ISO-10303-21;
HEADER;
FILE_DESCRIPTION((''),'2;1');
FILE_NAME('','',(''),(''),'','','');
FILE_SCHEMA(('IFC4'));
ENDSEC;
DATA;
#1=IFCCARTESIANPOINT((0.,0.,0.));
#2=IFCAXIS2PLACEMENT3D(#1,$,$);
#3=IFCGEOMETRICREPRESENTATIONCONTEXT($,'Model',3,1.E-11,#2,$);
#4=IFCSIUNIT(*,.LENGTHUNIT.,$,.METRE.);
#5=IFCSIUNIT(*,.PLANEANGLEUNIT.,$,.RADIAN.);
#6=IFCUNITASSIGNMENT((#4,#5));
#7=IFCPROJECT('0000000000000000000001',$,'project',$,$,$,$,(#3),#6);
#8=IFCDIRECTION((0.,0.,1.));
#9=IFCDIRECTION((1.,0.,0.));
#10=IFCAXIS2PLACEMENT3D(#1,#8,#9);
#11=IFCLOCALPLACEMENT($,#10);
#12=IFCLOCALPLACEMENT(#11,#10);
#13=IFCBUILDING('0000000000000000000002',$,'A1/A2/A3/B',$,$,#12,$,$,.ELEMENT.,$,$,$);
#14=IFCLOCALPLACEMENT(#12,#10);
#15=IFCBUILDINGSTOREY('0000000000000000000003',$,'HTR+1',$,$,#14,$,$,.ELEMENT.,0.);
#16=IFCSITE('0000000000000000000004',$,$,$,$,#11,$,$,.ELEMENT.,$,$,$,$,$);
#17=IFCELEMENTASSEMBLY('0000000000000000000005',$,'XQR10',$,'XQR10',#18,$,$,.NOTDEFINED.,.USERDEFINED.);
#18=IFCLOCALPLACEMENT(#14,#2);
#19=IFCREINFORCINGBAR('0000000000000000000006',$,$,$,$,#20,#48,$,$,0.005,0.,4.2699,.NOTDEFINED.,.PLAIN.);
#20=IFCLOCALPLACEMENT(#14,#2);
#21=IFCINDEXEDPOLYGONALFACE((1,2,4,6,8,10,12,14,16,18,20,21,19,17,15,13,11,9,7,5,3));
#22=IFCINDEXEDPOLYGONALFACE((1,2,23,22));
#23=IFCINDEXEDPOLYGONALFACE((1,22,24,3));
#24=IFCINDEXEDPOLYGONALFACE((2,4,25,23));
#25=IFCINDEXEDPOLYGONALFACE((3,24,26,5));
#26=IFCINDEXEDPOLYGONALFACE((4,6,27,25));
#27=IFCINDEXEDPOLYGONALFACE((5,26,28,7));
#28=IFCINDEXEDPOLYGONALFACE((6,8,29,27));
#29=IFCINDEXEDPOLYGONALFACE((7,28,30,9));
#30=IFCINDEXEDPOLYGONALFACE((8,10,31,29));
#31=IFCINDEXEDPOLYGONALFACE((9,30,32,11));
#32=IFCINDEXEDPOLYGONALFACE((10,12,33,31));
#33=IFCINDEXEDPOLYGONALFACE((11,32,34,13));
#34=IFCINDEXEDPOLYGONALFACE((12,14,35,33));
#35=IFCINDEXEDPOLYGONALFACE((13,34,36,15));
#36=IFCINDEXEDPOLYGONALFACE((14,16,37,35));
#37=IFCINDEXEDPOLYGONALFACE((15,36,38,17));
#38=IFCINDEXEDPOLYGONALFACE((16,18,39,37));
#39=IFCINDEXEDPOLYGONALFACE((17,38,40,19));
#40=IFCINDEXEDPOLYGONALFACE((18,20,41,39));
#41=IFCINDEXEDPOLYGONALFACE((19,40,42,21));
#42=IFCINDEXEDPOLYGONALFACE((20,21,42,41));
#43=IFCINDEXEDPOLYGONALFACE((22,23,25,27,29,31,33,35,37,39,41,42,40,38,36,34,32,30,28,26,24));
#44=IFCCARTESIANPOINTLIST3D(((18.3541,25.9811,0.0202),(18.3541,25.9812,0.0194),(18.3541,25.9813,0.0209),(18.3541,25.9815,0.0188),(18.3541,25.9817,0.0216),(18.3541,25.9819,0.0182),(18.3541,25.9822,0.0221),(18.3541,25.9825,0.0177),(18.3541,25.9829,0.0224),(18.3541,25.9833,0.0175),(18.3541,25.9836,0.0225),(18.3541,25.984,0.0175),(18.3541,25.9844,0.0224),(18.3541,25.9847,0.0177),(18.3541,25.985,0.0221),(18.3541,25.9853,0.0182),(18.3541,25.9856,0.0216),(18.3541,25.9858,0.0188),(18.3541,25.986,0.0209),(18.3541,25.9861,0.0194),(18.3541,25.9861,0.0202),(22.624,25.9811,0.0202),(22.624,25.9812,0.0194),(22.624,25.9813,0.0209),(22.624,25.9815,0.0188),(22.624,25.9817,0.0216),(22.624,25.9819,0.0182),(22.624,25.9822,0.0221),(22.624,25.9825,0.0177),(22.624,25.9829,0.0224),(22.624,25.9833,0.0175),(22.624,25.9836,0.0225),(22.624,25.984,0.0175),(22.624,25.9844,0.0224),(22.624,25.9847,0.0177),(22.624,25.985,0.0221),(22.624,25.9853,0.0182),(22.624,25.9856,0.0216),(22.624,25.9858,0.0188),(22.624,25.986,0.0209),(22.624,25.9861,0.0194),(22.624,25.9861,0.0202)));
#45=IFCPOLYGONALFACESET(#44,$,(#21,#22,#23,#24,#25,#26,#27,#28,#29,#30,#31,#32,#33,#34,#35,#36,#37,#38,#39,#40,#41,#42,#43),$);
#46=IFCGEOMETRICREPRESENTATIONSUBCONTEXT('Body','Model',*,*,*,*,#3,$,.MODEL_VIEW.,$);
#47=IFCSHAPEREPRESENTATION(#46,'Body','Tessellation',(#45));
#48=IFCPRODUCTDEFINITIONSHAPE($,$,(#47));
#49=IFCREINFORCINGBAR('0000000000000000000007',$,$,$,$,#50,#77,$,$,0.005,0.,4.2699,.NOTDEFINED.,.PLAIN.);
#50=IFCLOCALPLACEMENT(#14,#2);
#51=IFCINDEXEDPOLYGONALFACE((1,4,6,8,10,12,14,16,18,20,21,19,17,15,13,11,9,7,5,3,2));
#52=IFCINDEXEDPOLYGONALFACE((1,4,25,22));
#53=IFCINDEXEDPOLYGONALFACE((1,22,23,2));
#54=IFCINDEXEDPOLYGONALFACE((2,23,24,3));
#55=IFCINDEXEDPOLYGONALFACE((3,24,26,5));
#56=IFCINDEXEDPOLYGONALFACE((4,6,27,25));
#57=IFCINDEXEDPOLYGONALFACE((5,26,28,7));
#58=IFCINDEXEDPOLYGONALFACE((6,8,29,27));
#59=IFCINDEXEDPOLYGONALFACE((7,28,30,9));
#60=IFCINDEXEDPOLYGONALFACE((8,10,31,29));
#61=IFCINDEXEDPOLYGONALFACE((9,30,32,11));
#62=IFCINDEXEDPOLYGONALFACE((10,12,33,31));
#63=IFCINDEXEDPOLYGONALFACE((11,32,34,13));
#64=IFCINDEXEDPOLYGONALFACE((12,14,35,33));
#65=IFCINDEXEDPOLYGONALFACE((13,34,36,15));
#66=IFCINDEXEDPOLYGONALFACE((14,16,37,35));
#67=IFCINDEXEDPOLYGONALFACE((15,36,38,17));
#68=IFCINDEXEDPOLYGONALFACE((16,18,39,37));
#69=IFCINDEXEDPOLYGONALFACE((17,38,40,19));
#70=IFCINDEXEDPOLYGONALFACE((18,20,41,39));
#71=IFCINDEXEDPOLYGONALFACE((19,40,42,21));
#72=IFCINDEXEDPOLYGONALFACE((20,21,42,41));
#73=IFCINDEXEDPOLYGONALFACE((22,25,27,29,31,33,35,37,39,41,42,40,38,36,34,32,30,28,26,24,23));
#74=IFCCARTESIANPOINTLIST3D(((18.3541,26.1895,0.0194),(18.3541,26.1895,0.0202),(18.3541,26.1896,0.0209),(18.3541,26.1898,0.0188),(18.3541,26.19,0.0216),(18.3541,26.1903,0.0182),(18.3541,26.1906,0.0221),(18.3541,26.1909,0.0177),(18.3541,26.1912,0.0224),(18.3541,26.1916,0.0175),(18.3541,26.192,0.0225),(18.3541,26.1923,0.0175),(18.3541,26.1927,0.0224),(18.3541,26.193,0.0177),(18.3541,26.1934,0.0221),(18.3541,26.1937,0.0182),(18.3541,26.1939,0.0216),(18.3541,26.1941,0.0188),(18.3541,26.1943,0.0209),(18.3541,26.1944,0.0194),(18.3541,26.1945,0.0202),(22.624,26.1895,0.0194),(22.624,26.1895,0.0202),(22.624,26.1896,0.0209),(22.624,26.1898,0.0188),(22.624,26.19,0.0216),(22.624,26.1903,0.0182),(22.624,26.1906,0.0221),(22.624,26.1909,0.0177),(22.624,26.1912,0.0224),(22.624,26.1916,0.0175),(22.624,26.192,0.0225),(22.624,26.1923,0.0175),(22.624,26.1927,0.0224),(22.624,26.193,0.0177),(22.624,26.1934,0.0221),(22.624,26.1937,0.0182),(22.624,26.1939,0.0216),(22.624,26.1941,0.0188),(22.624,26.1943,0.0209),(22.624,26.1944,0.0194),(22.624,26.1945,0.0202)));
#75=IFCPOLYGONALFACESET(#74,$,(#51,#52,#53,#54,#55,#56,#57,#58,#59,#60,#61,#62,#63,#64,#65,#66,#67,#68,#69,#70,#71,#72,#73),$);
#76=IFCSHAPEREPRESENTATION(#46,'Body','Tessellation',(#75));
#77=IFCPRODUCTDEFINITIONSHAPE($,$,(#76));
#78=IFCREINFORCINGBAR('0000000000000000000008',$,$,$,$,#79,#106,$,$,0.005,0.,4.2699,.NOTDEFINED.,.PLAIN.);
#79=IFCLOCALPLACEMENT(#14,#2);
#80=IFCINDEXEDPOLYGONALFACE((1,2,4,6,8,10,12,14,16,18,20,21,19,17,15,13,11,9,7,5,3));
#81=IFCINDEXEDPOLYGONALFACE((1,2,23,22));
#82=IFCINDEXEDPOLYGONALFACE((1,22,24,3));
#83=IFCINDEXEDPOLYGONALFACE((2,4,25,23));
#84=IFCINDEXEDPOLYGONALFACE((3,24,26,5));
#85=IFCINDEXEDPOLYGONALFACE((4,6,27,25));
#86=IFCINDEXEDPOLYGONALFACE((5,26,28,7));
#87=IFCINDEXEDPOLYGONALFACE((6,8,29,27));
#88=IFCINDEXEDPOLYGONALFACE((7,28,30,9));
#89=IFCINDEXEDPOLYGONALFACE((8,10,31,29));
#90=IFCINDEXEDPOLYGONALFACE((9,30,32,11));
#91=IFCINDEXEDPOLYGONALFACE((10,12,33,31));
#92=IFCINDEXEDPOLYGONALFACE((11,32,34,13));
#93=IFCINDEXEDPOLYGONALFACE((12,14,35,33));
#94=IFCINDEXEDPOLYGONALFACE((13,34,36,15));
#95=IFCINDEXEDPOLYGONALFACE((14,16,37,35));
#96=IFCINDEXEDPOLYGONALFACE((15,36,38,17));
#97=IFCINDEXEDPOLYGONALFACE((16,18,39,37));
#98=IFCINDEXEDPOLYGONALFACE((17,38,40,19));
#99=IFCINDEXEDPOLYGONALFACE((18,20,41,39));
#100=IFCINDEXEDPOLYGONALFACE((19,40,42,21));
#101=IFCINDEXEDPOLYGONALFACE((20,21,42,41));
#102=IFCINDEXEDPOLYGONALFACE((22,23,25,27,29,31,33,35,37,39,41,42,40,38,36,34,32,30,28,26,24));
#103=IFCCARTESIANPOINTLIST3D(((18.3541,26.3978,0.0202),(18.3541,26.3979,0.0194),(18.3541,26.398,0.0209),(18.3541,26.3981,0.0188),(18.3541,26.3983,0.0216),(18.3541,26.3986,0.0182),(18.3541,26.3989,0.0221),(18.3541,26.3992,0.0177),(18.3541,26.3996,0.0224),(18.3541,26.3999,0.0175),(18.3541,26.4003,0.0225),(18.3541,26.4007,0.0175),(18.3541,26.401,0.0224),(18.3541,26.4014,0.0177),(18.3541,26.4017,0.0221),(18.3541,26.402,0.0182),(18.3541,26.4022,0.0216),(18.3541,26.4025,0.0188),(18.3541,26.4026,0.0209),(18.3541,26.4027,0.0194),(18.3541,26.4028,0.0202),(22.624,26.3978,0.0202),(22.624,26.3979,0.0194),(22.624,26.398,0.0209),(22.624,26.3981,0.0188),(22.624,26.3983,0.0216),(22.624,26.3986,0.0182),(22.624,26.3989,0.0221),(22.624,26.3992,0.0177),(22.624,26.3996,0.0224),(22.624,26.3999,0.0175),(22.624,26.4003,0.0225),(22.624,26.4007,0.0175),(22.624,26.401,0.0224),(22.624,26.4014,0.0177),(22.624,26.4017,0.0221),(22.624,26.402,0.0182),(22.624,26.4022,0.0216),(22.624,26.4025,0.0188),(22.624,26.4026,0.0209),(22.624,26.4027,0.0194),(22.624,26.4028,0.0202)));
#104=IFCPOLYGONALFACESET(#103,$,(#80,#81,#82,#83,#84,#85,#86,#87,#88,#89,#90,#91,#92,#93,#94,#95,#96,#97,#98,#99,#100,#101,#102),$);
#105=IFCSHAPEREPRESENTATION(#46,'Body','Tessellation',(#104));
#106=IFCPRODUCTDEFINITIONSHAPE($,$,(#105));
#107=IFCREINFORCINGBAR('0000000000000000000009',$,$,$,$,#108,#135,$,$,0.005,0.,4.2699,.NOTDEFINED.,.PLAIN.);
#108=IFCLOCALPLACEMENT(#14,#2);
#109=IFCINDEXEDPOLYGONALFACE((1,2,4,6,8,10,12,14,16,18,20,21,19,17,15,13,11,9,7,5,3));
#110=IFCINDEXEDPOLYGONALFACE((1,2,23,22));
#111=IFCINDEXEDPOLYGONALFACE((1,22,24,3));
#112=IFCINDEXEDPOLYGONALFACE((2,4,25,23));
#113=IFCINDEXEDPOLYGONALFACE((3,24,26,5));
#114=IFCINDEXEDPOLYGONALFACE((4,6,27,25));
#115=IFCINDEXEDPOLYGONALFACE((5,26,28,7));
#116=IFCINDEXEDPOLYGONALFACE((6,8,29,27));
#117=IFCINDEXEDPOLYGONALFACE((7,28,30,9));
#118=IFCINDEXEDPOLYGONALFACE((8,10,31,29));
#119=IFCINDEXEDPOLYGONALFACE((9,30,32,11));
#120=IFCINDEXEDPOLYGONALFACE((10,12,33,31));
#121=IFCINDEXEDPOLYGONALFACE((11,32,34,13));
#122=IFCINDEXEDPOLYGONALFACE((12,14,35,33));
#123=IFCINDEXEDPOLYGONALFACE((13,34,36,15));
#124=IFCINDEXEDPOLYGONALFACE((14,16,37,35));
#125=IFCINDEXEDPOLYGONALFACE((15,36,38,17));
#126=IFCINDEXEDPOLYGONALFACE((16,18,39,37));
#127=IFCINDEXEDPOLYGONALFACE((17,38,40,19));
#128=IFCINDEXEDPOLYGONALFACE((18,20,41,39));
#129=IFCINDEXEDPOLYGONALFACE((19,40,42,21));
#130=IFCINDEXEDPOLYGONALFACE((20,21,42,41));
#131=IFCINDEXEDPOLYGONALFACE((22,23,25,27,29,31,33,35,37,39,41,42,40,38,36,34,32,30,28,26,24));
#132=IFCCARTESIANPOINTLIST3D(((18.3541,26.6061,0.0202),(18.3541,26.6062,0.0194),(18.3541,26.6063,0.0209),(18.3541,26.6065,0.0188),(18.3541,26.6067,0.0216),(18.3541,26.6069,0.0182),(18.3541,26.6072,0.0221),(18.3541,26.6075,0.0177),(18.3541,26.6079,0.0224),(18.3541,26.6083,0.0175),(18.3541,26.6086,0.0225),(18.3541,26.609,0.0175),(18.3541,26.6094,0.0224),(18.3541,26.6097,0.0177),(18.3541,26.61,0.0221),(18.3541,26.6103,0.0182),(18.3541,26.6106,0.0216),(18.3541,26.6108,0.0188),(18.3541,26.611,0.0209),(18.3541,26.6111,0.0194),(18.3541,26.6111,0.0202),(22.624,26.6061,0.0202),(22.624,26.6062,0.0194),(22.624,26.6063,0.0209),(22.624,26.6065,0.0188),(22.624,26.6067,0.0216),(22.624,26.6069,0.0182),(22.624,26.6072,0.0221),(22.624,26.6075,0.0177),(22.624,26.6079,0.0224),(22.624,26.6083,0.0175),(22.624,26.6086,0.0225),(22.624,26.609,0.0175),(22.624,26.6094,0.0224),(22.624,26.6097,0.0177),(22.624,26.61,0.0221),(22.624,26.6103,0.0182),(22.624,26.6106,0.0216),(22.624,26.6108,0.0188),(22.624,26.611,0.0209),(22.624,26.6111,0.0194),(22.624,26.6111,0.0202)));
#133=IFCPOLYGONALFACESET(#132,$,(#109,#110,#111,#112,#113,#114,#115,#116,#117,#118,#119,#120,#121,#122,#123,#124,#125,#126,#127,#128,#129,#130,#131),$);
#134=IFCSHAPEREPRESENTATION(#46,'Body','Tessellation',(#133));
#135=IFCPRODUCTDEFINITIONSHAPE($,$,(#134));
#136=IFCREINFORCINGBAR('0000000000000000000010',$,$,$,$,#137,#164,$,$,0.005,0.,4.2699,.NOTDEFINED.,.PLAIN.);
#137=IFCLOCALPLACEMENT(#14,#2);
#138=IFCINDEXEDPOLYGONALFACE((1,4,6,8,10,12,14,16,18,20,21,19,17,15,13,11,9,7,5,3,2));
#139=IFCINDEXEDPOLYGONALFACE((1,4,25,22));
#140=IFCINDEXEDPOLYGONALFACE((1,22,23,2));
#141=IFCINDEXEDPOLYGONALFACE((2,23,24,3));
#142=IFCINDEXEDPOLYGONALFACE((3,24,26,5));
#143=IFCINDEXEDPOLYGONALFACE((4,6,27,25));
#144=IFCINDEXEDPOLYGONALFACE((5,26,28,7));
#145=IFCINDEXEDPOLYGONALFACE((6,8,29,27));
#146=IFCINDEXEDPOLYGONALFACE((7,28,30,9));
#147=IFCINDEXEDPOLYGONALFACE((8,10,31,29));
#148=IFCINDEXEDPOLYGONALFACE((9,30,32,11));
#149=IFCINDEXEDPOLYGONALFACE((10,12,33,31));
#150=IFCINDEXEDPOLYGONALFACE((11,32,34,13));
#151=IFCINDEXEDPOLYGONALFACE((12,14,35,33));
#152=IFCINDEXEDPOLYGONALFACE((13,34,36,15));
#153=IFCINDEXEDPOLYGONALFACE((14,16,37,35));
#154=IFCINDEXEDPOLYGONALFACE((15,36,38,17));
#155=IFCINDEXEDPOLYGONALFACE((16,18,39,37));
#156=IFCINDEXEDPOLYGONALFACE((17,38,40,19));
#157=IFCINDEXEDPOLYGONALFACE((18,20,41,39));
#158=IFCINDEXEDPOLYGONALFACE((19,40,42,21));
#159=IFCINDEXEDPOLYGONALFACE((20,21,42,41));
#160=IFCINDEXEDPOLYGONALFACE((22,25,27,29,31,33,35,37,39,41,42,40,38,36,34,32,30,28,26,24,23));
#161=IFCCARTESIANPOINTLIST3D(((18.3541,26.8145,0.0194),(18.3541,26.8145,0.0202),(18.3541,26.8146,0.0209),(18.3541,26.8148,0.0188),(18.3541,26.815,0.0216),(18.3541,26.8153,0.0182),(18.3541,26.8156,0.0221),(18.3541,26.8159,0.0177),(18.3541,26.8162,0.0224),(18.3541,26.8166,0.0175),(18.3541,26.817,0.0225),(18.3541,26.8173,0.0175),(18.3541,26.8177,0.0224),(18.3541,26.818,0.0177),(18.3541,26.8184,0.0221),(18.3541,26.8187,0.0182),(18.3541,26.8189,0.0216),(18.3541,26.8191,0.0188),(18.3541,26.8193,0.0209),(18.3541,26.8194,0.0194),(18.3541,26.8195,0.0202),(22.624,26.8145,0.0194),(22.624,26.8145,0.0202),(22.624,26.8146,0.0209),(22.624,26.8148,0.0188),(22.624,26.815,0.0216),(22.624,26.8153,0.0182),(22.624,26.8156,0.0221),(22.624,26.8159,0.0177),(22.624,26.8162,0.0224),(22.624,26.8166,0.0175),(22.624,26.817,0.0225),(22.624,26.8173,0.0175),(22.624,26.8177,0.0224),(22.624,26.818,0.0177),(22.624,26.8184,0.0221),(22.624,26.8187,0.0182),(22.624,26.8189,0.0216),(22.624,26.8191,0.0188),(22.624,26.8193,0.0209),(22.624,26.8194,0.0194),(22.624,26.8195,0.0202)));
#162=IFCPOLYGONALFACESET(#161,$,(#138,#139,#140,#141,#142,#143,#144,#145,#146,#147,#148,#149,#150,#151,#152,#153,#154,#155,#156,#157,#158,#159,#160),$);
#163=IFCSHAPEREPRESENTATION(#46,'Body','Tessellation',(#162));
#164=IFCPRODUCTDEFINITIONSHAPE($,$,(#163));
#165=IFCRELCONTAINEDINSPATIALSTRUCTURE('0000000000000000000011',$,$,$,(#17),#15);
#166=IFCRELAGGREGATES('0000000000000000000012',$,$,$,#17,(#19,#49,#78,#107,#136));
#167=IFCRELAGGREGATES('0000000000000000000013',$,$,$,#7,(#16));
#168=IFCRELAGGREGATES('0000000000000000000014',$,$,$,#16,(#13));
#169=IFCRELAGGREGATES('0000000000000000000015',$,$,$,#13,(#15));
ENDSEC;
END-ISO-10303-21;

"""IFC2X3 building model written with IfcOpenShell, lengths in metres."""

from ifc_helpers import new_model, entity, si_unit, origin, origin_with_axes, place, context, subcontext, project, spatial, shape, element, aggregate, save


model = new_model("IFC2X3")

# Units and contexts
model_context = context("Model", 3, precision=1e-11, world=origin())
body_context = subcontext(model_context, "Body", "Model", "MODEL_VIEW")
ifc_project = project(units=[si_unit("LENGTHUNIT", "METRE"), si_unit("PLANEANGLEUNIT", "RADIAN")], contexts=[model_context])

# Site, building, storey
site_placement = place(None, origin_with_axes())
site = spatial("IfcSite", under=ifc_project, at=site_placement, CompositionType="ELEMENT")
building_placement = place(site_placement, origin_with_axes())
building = spatial("IfcBuilding", under=site, at=building_placement, Name="A1/A2/A3/B", CompositionType="ELEMENT")
storey_placement = place(building_placement, origin_with_axes())
storey = spatial("IfcBuildingStorey", under=building, at=storey_placement, Name="HTR+1", CompositionType="ELEMENT", Elevation=0.0)

# Element assembly, reinforcing bars
assembly_1_placement = place(storey_placement, origin_with_axes())
assembly_1 = element("IfcElementAssembly", 1, at=assembly_1_placement, inside=storey, Name="XQR10", ObjectType="XQR10", AssemblyPlace="NOTDEFINED", PredefinedType="USERDEFINED")
reinforcing_bar_1_placement = place(assembly_1_placement, origin_with_axes())
reinforcing_bar_1 = element("IfcReinforcingBar", 2, at=reinforcing_bar_1_placement, BarLength=4.2699, BarRole="NOTDEFINED", BarSurface="PLAIN", CrossSectionArea=0.0, NominalDiameter=0.005, shapes=[
    shape(body_context, "Body", "AdvancedSweptSolid", [entity("IfcSweptDiskSolid", entity("IfcPolyline", [entity("IfcCartesianPoint", [18.3541, 25.9836, 0.02]), entity("IfcCartesianPoint", [22.624, 25.9836, 0.02])]), 0.0025, None, 0.0, 4.2699)]),
    shape(body_context, "Body", "AdvancedSweptSolid", [entity("IfcSweptDiskSolid", entity("IfcPolyline", [entity("IfcCartesianPoint", [18.3541, 25.9836, 0.02]), entity("IfcCartesianPoint", [22.624, 25.9836, 0.02])]), 0.0025, None, 0.0, 4.2699)]),
])
reinforcing_bar_2_placement = place(assembly_1_placement, origin_with_axes())
reinforcing_bar_2 = element("IfcReinforcingBar", 3, at=reinforcing_bar_2_placement, BarLength=4.2699, BarRole="NOTDEFINED", BarSurface="PLAIN", CrossSectionArea=0.0, NominalDiameter=0.005, shapes=[
    shape(body_context, "Body", "AdvancedSweptSolid", [entity("IfcSweptDiskSolid", entity("IfcPolyline", [entity("IfcCartesianPoint", [18.3541, 26.192, 0.02]), entity("IfcCartesianPoint", [22.624, 26.192, 0.02])]), 0.0025, None, 0.0, 4.2699)]),
    shape(body_context, "Body", "AdvancedSweptSolid", [entity("IfcSweptDiskSolid", entity("IfcPolyline", [entity("IfcCartesianPoint", [18.3541, 26.192, 0.02]), entity("IfcCartesianPoint", [22.624, 26.192, 0.02])]), 0.0025, None, 0.0, 4.2699)]),
])
reinforcing_bar_3_placement = place(assembly_1_placement, origin_with_axes())
reinforcing_bar_3 = element("IfcReinforcingBar", 4, at=reinforcing_bar_3_placement, BarLength=4.2699, BarRole="NOTDEFINED", BarSurface="PLAIN", CrossSectionArea=0.0, NominalDiameter=0.005, shapes=[
    shape(body_context, "Body", "AdvancedSweptSolid", [entity("IfcSweptDiskSolid", entity("IfcPolyline", [entity("IfcCartesianPoint", [18.3541, 26.4003, 0.02]), entity("IfcCartesianPoint", [22.624, 26.4003, 0.02])]), 0.0025, None, 0.0, 4.2699)]),
    shape(body_context, "Body", "AdvancedSweptSolid", [entity("IfcSweptDiskSolid", entity("IfcPolyline", [entity("IfcCartesianPoint", [18.3541, 26.4003, 0.02]), entity("IfcCartesianPoint", [22.624, 26.4003, 0.02])]), 0.0025, None, 0.0, 4.2699)]),
])
reinforcing_bar_4_placement = place(assembly_1_placement, origin_with_axes())
reinforcing_bar_4 = element("IfcReinforcingBar", 5, at=reinforcing_bar_4_placement, BarLength=4.2699, BarRole="NOTDEFINED", BarSurface="PLAIN", CrossSectionArea=0.0, NominalDiameter=0.005, shapes=[
    shape(body_context, "Body", "AdvancedSweptSolid", [entity("IfcSweptDiskSolid", entity("IfcPolyline", [entity("IfcCartesianPoint", [18.3541, 26.6086, 0.02]), entity("IfcCartesianPoint", [22.624, 26.6086, 0.02])]), 0.0025, None, 0.0, 4.2699)]),
    shape(body_context, "Body", "AdvancedSweptSolid", [entity("IfcSweptDiskSolid", entity("IfcPolyline", [entity("IfcCartesianPoint", [18.3541, 26.6086, 0.02]), entity("IfcCartesianPoint", [22.624, 26.6086, 0.02])]), 0.0025, None, 0.0, 4.2699)]),
])
reinforcing_bar_5_placement = place(assembly_1_placement, origin_with_axes())
reinforcing_bar_5 = element("IfcReinforcingBar", 6, at=reinforcing_bar_5_placement, BarLength=4.2699, BarRole="NOTDEFINED", BarSurface="PLAIN", CrossSectionArea=0.0, NominalDiameter=0.005, shapes=[
    shape(body_context, "Body", "AdvancedSweptSolid", [entity("IfcSweptDiskSolid", entity("IfcPolyline", [entity("IfcCartesianPoint", [18.3541, 26.817, 0.02]), entity("IfcCartesianPoint", [22.624, 26.817, 0.02])]), 0.0025, None, 0.0, 4.2699)]),
    shape(body_context, "Body", "AdvancedSweptSolid", [entity("IfcSweptDiskSolid", entity("IfcPolyline", [entity("IfcCartesianPoint", [18.3541, 26.817, 0.02]), entity("IfcCartesianPoint", [22.624, 26.817, 0.02])]), 0.0025, None, 0.0, 4.2699)]),
])
aggregate(assembly_1, [reinforcing_bar_1, reinforcing_bar_2, reinforcing_bar_3, reinforcing_bar_4, reinforcing_bar_5])

save(model, "model.ifc")
